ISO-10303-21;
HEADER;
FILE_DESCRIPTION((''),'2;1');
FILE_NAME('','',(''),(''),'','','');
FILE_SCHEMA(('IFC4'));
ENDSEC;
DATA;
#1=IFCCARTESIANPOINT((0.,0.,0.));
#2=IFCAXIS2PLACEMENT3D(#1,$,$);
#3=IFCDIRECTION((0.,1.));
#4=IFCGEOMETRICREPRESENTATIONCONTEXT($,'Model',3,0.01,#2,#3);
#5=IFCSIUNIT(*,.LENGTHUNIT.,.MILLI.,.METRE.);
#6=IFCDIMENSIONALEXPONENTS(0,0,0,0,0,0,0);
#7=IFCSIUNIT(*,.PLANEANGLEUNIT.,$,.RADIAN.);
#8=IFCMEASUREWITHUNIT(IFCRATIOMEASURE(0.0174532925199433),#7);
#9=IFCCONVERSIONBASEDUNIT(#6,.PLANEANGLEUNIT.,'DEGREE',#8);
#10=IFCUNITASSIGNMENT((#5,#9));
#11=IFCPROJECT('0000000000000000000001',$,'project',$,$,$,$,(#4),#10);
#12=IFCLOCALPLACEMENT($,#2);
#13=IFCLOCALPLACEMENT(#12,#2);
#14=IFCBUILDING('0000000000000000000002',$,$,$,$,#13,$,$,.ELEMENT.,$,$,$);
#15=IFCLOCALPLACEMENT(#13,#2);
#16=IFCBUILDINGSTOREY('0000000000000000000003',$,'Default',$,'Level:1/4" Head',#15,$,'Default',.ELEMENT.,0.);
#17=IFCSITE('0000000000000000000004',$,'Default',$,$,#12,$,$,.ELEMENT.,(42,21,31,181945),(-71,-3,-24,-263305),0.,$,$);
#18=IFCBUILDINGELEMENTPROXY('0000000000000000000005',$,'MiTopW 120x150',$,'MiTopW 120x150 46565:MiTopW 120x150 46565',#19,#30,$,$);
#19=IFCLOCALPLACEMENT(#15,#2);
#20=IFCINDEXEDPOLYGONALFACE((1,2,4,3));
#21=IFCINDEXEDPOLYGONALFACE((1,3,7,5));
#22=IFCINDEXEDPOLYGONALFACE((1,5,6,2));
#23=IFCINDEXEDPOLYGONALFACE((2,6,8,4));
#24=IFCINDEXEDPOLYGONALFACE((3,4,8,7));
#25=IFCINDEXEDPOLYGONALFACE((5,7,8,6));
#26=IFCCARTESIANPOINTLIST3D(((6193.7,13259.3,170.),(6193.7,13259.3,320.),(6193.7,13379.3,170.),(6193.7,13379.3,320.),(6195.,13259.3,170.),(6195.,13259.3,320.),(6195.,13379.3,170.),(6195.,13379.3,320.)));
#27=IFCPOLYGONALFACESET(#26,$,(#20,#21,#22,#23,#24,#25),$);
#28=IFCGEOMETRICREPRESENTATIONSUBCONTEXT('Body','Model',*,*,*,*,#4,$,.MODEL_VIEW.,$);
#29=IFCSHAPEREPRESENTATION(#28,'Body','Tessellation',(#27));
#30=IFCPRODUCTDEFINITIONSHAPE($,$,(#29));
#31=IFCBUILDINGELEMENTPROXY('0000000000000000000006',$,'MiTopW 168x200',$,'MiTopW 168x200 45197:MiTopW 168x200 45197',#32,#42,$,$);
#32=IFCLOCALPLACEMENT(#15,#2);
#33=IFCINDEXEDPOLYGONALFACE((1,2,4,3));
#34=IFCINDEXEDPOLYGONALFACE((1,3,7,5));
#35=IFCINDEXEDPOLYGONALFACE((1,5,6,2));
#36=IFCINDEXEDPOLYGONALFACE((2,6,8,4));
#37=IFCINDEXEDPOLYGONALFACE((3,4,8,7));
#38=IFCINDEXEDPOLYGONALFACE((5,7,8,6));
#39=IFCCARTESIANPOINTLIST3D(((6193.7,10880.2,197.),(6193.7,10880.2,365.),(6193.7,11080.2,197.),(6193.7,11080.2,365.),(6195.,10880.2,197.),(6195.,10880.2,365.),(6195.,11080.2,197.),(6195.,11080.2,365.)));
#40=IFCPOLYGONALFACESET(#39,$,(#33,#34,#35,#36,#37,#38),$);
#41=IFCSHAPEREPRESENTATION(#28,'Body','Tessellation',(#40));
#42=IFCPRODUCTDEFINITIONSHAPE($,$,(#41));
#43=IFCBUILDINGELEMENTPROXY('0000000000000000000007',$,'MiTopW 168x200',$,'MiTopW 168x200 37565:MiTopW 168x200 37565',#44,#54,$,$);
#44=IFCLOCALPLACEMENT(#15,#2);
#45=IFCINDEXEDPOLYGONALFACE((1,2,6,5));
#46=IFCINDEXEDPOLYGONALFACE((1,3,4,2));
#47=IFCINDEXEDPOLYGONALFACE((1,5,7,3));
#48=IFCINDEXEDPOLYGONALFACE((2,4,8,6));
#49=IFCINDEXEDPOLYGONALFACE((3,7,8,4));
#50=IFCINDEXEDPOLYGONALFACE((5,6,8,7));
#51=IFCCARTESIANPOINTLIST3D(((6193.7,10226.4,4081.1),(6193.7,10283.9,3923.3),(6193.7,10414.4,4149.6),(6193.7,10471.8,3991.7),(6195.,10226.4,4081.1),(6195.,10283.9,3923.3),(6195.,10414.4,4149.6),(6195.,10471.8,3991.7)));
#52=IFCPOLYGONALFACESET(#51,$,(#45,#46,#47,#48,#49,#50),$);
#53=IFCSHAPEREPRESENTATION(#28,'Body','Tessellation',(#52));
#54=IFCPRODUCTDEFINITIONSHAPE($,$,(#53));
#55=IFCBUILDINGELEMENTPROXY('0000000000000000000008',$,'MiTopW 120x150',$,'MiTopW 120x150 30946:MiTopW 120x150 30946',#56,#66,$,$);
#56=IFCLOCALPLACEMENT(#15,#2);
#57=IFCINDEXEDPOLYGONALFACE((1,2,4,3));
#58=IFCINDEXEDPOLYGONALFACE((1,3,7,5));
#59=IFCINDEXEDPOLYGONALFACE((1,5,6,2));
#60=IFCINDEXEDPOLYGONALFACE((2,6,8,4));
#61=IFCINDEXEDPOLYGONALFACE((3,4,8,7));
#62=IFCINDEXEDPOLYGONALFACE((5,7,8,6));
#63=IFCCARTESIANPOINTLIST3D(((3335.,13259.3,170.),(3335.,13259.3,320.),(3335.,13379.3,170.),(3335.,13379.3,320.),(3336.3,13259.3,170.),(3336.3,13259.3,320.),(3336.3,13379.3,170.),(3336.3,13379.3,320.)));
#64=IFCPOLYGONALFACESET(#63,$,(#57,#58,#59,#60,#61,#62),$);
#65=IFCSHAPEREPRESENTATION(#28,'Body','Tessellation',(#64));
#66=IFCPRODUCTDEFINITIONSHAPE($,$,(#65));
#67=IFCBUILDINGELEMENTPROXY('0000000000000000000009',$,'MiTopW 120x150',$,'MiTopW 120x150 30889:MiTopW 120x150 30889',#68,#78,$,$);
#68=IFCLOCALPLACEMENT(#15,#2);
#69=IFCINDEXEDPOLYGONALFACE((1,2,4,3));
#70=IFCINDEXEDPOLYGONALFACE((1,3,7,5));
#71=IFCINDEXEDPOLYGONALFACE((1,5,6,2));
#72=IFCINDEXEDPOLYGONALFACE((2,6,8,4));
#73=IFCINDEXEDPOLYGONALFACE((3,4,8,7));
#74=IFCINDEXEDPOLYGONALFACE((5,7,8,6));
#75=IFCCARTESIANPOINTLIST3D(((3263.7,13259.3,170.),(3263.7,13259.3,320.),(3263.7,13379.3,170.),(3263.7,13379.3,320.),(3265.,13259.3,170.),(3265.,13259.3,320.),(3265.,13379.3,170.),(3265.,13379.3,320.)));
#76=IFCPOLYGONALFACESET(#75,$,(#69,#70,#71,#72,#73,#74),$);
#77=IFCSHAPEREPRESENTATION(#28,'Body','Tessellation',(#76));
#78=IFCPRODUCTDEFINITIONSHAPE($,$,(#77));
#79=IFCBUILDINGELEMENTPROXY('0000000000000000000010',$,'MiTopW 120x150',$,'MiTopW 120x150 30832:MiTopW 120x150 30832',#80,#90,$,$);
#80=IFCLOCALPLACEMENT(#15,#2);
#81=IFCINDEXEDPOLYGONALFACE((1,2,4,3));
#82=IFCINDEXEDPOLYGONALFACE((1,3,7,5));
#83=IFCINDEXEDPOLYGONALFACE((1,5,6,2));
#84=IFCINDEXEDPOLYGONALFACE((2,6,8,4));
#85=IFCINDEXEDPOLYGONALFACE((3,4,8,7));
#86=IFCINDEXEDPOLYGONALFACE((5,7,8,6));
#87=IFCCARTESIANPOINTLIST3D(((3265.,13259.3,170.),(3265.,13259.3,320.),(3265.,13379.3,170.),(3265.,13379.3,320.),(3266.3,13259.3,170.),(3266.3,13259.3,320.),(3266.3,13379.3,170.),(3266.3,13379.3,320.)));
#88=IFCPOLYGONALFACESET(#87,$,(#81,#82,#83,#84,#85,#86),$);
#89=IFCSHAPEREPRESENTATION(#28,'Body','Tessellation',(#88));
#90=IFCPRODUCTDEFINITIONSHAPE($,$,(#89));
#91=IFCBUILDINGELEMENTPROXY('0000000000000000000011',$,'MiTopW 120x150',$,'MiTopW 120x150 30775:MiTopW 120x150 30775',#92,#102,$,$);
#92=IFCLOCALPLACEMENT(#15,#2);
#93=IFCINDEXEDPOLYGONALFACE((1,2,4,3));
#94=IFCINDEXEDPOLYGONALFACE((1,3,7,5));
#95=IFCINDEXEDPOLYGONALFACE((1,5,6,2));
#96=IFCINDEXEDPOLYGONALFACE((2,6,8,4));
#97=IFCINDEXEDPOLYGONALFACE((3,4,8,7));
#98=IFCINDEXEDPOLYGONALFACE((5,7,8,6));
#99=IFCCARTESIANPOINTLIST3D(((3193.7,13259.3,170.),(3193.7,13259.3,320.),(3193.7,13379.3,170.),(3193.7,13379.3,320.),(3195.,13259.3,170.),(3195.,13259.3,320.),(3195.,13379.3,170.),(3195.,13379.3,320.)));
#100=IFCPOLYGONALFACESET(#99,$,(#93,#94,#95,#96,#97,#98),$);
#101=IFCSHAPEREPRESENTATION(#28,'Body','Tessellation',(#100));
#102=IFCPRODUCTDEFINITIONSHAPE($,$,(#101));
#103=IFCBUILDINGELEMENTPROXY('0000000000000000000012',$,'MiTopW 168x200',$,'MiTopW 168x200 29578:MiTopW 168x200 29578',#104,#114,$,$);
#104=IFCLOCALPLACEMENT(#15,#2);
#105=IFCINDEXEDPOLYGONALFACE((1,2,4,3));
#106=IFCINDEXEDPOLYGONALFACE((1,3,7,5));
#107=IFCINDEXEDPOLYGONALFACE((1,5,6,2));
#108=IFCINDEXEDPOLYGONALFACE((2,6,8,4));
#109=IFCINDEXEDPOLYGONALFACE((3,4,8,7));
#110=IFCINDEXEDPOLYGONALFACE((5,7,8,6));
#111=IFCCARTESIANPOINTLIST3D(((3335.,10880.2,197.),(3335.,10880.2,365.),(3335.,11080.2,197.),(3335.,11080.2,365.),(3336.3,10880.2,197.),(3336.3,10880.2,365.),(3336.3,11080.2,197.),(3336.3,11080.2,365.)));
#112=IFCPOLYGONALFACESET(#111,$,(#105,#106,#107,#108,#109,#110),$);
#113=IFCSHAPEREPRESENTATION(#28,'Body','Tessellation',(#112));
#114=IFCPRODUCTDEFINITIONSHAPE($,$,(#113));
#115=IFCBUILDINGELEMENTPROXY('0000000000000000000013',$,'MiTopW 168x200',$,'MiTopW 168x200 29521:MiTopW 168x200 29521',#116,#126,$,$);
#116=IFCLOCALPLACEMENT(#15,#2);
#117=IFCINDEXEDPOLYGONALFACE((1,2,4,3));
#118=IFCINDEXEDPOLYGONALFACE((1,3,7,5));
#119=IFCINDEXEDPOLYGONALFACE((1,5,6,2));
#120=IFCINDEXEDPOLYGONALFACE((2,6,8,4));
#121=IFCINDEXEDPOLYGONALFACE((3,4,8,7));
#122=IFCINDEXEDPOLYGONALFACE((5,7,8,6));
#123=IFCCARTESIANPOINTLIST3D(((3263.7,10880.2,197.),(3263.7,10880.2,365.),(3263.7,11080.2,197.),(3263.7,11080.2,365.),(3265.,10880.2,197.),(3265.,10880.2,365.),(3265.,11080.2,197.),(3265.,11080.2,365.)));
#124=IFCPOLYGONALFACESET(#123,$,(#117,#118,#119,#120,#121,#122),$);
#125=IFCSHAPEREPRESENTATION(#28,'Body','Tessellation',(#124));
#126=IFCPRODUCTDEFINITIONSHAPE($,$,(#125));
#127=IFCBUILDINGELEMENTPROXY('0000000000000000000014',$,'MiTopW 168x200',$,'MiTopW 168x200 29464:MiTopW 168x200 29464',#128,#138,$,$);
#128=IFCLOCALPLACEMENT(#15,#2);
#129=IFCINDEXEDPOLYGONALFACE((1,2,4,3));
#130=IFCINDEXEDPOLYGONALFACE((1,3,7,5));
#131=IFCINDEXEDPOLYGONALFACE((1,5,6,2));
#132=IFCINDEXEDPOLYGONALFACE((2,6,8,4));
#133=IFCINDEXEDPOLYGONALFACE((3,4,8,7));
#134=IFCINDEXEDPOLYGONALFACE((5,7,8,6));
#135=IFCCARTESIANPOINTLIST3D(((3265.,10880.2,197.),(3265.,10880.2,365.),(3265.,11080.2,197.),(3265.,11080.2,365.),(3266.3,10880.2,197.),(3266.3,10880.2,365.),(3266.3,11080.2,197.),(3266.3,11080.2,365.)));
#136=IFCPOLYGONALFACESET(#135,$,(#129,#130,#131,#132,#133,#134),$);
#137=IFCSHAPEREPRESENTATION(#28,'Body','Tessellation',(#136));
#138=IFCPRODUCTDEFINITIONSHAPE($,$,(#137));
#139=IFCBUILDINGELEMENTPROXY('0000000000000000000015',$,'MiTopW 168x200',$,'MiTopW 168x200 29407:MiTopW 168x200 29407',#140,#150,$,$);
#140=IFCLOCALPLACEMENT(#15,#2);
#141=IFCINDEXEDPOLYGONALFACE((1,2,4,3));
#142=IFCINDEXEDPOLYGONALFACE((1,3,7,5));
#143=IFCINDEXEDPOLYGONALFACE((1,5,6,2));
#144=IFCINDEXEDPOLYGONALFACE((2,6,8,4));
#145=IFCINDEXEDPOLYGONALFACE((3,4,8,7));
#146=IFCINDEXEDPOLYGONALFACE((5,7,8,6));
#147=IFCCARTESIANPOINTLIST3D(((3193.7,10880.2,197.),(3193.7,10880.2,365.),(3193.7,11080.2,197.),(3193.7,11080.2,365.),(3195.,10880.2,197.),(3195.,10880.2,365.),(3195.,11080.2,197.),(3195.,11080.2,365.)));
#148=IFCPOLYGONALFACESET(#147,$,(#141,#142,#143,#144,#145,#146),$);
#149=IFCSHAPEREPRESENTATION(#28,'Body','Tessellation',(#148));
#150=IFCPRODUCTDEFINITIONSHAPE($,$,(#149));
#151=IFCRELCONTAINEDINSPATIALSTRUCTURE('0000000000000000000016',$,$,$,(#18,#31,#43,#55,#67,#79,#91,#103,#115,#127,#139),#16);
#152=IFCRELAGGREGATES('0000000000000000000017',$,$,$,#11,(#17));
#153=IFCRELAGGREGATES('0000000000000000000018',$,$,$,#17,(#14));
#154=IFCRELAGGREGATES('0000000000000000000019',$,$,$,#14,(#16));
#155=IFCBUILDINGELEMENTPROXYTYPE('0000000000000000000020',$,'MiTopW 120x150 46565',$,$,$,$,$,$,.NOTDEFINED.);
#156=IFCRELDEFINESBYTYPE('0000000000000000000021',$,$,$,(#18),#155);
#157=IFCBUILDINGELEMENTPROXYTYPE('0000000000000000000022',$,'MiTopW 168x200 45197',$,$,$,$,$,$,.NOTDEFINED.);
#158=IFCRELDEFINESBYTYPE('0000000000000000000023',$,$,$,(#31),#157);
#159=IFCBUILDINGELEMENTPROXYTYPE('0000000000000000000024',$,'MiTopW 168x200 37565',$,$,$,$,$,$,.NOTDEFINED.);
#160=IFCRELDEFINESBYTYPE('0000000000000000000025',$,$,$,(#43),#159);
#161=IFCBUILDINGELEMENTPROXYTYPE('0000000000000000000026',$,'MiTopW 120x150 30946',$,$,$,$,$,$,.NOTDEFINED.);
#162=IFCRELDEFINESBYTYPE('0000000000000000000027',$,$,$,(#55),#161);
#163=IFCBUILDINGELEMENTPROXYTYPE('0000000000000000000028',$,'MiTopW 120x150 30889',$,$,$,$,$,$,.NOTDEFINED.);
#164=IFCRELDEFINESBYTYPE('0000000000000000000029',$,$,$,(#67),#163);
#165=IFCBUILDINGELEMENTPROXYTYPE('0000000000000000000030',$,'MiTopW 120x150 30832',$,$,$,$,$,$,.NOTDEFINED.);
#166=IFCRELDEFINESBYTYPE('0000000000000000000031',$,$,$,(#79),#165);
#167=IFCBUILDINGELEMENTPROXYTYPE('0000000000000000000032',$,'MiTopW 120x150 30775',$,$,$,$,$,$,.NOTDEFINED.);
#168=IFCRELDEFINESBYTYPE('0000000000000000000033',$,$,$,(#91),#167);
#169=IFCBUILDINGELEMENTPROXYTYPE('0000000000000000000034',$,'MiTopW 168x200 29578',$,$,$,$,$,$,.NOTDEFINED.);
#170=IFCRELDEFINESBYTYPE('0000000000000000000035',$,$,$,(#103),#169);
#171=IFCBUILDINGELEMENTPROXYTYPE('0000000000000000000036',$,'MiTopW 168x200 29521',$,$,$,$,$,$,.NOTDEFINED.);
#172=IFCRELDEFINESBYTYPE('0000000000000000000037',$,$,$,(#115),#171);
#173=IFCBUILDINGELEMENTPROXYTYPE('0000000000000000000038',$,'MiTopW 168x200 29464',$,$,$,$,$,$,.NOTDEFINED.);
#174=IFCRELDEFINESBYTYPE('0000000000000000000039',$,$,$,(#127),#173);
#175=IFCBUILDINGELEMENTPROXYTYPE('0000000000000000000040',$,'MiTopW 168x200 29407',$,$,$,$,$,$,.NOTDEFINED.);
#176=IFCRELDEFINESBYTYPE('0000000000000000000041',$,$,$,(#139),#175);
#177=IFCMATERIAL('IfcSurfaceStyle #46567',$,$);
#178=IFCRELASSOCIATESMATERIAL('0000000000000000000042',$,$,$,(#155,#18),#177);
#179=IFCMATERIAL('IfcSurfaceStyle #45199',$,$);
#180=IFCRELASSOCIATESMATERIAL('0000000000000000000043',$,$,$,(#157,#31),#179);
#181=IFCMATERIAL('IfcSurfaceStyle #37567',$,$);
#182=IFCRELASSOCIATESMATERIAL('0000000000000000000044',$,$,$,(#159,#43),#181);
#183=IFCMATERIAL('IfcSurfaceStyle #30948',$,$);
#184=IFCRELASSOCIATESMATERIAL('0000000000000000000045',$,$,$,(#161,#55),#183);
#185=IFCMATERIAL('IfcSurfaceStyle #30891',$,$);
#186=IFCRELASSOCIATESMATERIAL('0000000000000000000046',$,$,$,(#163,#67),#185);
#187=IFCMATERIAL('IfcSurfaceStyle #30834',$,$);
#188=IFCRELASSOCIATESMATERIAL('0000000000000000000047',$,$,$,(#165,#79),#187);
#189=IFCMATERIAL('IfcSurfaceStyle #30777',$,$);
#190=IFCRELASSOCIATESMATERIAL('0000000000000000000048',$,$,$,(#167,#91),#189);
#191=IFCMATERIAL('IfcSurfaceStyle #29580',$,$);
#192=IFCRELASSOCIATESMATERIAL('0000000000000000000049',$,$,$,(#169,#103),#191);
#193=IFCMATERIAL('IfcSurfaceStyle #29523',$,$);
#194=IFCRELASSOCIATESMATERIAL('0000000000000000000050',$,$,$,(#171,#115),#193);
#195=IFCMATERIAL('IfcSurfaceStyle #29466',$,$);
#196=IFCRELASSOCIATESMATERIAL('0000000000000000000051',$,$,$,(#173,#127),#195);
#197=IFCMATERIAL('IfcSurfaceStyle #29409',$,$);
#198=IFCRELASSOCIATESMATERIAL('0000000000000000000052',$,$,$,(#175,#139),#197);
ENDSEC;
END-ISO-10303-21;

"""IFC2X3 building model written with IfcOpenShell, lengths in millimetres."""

from ifc_helpers import new_model, entity, si_unit, converted_unit, direction, frame, origin, origin_2d_with_axis, place, context, subcontext, project, spatial, polyline, rectangle, outline, extrude, source, transform, mapped, material, type_object, type_shapes, element, save


model = new_model("IFC2X3")

# Units and contexts
model_context = context("Model", 3, precision=0.01, world=origin(), true_north=direction((0.0, 1.0)))
body_context = subcontext(model_context, "Body", "Model", "MODEL_VIEW")
ifc_project = project(units=[si_unit("LENGTHUNIT", "METRE", prefix="MILLI"), converted_unit("PLANEANGLEUNIT", "DEGREE", entity("IfcRatioMeasure", 0.0174532925199433), si_unit("PLANEANGLEUNIT", "RADIAN"), dimensions=[0, 0, 0, 0, 0, 0, 0])], contexts=[model_context])

# Site, building, storey
site_placement = place(None, origin())
site = spatial("IfcSite", under=ifc_project, at=site_placement, Name="Default", CompositionType="ELEMENT", RefLatitude=(42, 21, 31, 181945), RefLongitude=(-71, -3, -24, -263305), RefElevation=0.0)
building_placement = place(site_placement, origin())
building = spatial("IfcBuilding", under=site, at=building_placement, CompositionType="ELEMENT")
storey_placement = place(building_placement, origin())
storey = spatial("IfcBuildingStorey", under=building, at=storey_placement, Name="Default", ObjectType="Level:1/4\" Head", LongName="Default", CompositionType="ELEMENT", Elevation=0.0)

# Building element proxies
ifc_material_1 = material(Name="IfcSurfaceStyle #46567")
building_element_proxy_type_1 = type_object("IfcBuildingElementProxyType", Name="MiTopW 120x150 46565", PredefinedType="NOTDEFINED", material=ifc_material_1)
shared_shape_1 = source(origin(), body_context, "Body", "SweptSolid", [
    extrude(rectangle(XDim=150.0, YDim=120.0, at=origin_2d_with_axis()), frame((75.0, 60.0, 0.0), z_axis=(0.0, 0.0, 1.0), x_axis=(-1.0, 0.0, 0.0)), (0.0, 0.0, 1.0), 1.3),
])
type_shapes(building_element_proxy_type_1, [shared_shape_1])
proxy_1_placement = place(building_placement, frame((6195.0, 13259.3, 170.0), z_axis=(-1.0, 0.0, 0.0), x_axis=(0.0, 0.0, 1.0)))
element("IfcBuildingElementProxy", 1, at=proxy_1_placement, inside=storey, type_object=building_element_proxy_type_1, material=ifc_material_1, Name="MiTopW 120x150", ObjectType="MiTopW 120x150 46565:MiTopW 120x150 46565", context=body_context, shape_type="MappedRepresentation", body=[
    mapped(shared_shape_1, transform((0.0, 0.0, 0.0), scale=1.0)),
])
ifc_material_2 = material(Name="IfcSurfaceStyle #45199")
building_element_proxy_type_2 = type_object("IfcBuildingElementProxyType", Name="MiTopW 168x200 45197", PredefinedType="NOTDEFINED", material=ifc_material_2)
shared_shape_2 = source(origin(), body_context, "Body", "SweptSolid", [
    extrude(rectangle(XDim=200.0, YDim=168.0, at=origin_2d_with_axis()), frame((100.0, 84.0, 0.0), z_axis=(0.0, 0.0, 1.0), x_axis=(-1.0, 0.0, 0.0)), (0.0, 0.0, 1.0), 1.3),
])
type_shapes(building_element_proxy_type_2, [shared_shape_2])
proxy_2_placement = place(building_placement, frame((6195.0, 10880.2, 365.0), z_axis=(-1.0, 0.0, 0.0), x_axis=(0.0, 1.0, 0.0)))
element("IfcBuildingElementProxy", 2, at=proxy_2_placement, inside=storey, type_object=building_element_proxy_type_2, material=ifc_material_2, Name="MiTopW 168x200", ObjectType="MiTopW 168x200 45197:MiTopW 168x200 45197", context=body_context, shape_type="MappedRepresentation", body=[
    mapped(shared_shape_2, transform((0.0, 0.0, 0.0), scale=1.0)),
])
ifc_material_3 = material(Name="IfcSurfaceStyle #37567")
building_element_proxy_type_3 = type_object("IfcBuildingElementProxyType", Name="MiTopW 168x200 37565", PredefinedType="NOTDEFINED", material=ifc_material_3)
shared_shape_3 = source(origin(), body_context, "Body", "SweptSolid", [
    extrude(outline(polyline([(-100.0, -84.0), (100.0, -84.0), (100.0, 84.0), (-100.0, 84.0), (-100.0, -84.0)])), frame((100.0, 84.0, 0.0), z_axis=(0.0, 0.0, 1.0), x_axis=(-1.0, 0.0, 0.0)), (0.0, 0.0, 1.0), 1.3),
])
type_shapes(building_element_proxy_type_3, [shared_shape_3])
proxy_3_placement = place(building_placement, frame((6195.0, 10226.4, 4081.1), z_axis=(-1.0, 0.0, 0.0), x_axis=(0.0, 0.939693, 0.34202)))
element("IfcBuildingElementProxy", 3, at=proxy_3_placement, inside=storey, type_object=building_element_proxy_type_3, material=ifc_material_3, Name="MiTopW 168x200", ObjectType="MiTopW 168x200 37565:MiTopW 168x200 37565", context=body_context, shape_type="MappedRepresentation", body=[
    mapped(shared_shape_3, transform((0.0, 0.0, 0.0), scale=1.0)),
])
ifc_material_4 = material(Name="IfcSurfaceStyle #30948")
building_element_proxy_type_4 = type_object("IfcBuildingElementProxyType", Name="MiTopW 120x150 30946", PredefinedType="NOTDEFINED", material=ifc_material_4)
shared_shape_4 = source(origin(), body_context, "Body", "SweptSolid", [
    extrude(rectangle(XDim=150.0, YDim=120.0, at=origin_2d_with_axis()), frame((75.0, 60.0, 0.0), z_axis=(0.0, 0.0, 1.0), x_axis=(-1.0, 0.0, 0.0)), (0.0, 0.0, 1.0), 1.3),
])
type_shapes(building_element_proxy_type_4, [shared_shape_4])
proxy_4_placement = place(building_placement, frame((3336.3, 13259.3, 170.0), z_axis=(-1.0, 0.0, 0.0), x_axis=(0.0, 0.0, 1.0)))
element("IfcBuildingElementProxy", 4, at=proxy_4_placement, inside=storey, type_object=building_element_proxy_type_4, material=ifc_material_4, Name="MiTopW 120x150", ObjectType="MiTopW 120x150 30946:MiTopW 120x150 30946", context=body_context, shape_type="MappedRepresentation", body=[
    mapped(shared_shape_4, transform((0.0, 0.0, 0.0), scale=1.0)),
])
ifc_material_5 = material(Name="IfcSurfaceStyle #30891")
building_element_proxy_type_5 = type_object("IfcBuildingElementProxyType", Name="MiTopW 120x150 30889", PredefinedType="NOTDEFINED", material=ifc_material_5)
shared_shape_5 = source(origin(), body_context, "Body", "SweptSolid", [
    extrude(rectangle(XDim=150.0, YDim=120.0, at=origin_2d_with_axis()), frame((75.0, 60.0, 0.0), z_axis=(0.0, 0.0, 1.0), x_axis=(-1.0, 0.0, 0.0)), (0.0, 0.0, 1.0), 1.3),
])
type_shapes(building_element_proxy_type_5, [shared_shape_5])
proxy_5_placement = place(building_placement, frame((3265.0, 13259.3, 170.0), z_axis=(-1.0, 0.0, 0.0), x_axis=(0.0, 0.0, 1.0)))
element("IfcBuildingElementProxy", 5, at=proxy_5_placement, inside=storey, type_object=building_element_proxy_type_5, material=ifc_material_5, Name="MiTopW 120x150", ObjectType="MiTopW 120x150 30889:MiTopW 120x150 30889", context=body_context, shape_type="MappedRepresentation", body=[
    mapped(shared_shape_5, transform((0.0, 0.0, 0.0), scale=1.0)),
])
ifc_material_6 = material(Name="IfcSurfaceStyle #30834")
building_element_proxy_type_6 = type_object("IfcBuildingElementProxyType", Name="MiTopW 120x150 30832", PredefinedType="NOTDEFINED", material=ifc_material_6)
shared_shape_6 = source(origin(), body_context, "Body", "SweptSolid", [
    extrude(rectangle(XDim=150.0, YDim=120.0, at=origin_2d_with_axis()), frame((75.0, 60.0, 0.0), z_axis=(0.0, 0.0, 1.0), x_axis=(-1.0, 0.0, 0.0)), (0.0, 0.0, 1.0), 1.3),
])
type_shapes(building_element_proxy_type_6, [shared_shape_6])
proxy_6_placement = place(building_placement, frame((3266.3, 13259.3, 170.0), z_axis=(-1.0, 0.0, 0.0), x_axis=(0.0, 0.0, 1.0)))
element("IfcBuildingElementProxy", 6, at=proxy_6_placement, inside=storey, type_object=building_element_proxy_type_6, material=ifc_material_6, Name="MiTopW 120x150", ObjectType="MiTopW 120x150 30832:MiTopW 120x150 30832", context=body_context, shape_type="MappedRepresentation", body=[
    mapped(shared_shape_6, transform((0.0, 0.0, 0.0), scale=1.0)),
])
ifc_material_7 = material(Name="IfcSurfaceStyle #30777")
building_element_proxy_type_7 = type_object("IfcBuildingElementProxyType", Name="MiTopW 120x150 30775", PredefinedType="NOTDEFINED", material=ifc_material_7)
shared_shape_7 = source(origin(), body_context, "Body", "SweptSolid", [
    extrude(rectangle(XDim=150.0, YDim=120.0, at=origin_2d_with_axis()), frame((75.0, 60.0, 0.0), z_axis=(0.0, 0.0, 1.0), x_axis=(-1.0, 0.0, 0.0)), (0.0, 0.0, 1.0), 1.3),
])
type_shapes(building_element_proxy_type_7, [shared_shape_7])
proxy_7_placement = place(building_placement, frame((3195.0, 13259.3, 170.0), z_axis=(-1.0, 0.0, 0.0), x_axis=(0.0, 0.0, 1.0)))
element("IfcBuildingElementProxy", 7, at=proxy_7_placement, inside=storey, type_object=building_element_proxy_type_7, material=ifc_material_7, Name="MiTopW 120x150", ObjectType="MiTopW 120x150 30775:MiTopW 120x150 30775", context=body_context, shape_type="MappedRepresentation", body=[
    mapped(shared_shape_7, transform((0.0, 0.0, 0.0), scale=1.0)),
])
ifc_material_8 = material(Name="IfcSurfaceStyle #29580")
building_element_proxy_type_8 = type_object("IfcBuildingElementProxyType", Name="MiTopW 168x200 29578", PredefinedType="NOTDEFINED", material=ifc_material_8)
shared_shape_8 = source(origin(), body_context, "Body", "SweptSolid", [
    extrude(rectangle(XDim=200.0, YDim=168.0, at=origin_2d_with_axis()), frame((100.0, 84.0, 0.0), z_axis=(0.0, 0.0, 1.0), x_axis=(-1.0, 0.0, 0.0)), (0.0, 0.0, 1.0), 1.3),
])
type_shapes(building_element_proxy_type_8, [shared_shape_8])
proxy_8_placement = place(building_placement, frame((3336.3, 10880.2, 365.0), z_axis=(-1.0, 0.0, 0.0), x_axis=(0.0, 1.0, 0.0)))
element("IfcBuildingElementProxy", 8, at=proxy_8_placement, inside=storey, type_object=building_element_proxy_type_8, material=ifc_material_8, Name="MiTopW 168x200", ObjectType="MiTopW 168x200 29578:MiTopW 168x200 29578", context=body_context, shape_type="MappedRepresentation", body=[
    mapped(shared_shape_8, transform((0.0, 0.0, 0.0), scale=1.0)),
])
ifc_material_9 = material(Name="IfcSurfaceStyle #29523")
building_element_proxy_type_9 = type_object("IfcBuildingElementProxyType", Name="MiTopW 168x200 29521", PredefinedType="NOTDEFINED", material=ifc_material_9)
shared_shape_9 = source(origin(), body_context, "Body", "SweptSolid", [
    extrude(rectangle(XDim=200.0, YDim=168.0, at=origin_2d_with_axis()), frame((100.0, 84.0, 0.0), z_axis=(0.0, 0.0, 1.0), x_axis=(-1.0, 0.0, 0.0)), (0.0, 0.0, 1.0), 1.3),
])
type_shapes(building_element_proxy_type_9, [shared_shape_9])
proxy_9_placement = place(building_placement, frame((3265.0, 10880.2, 365.0), z_axis=(-1.0, 0.0, 0.0), x_axis=(0.0, 1.0, 0.0)))
element("IfcBuildingElementProxy", 9, at=proxy_9_placement, inside=storey, type_object=building_element_proxy_type_9, material=ifc_material_9, Name="MiTopW 168x200", ObjectType="MiTopW 168x200 29521:MiTopW 168x200 29521", context=body_context, shape_type="MappedRepresentation", body=[
    mapped(shared_shape_9, transform((0.0, 0.0, 0.0), scale=1.0)),
])
ifc_material_10 = material(Name="IfcSurfaceStyle #29466")
building_element_proxy_type_10 = type_object("IfcBuildingElementProxyType", Name="MiTopW 168x200 29464", PredefinedType="NOTDEFINED", material=ifc_material_10)
shared_shape_10 = source(origin(), body_context, "Body", "SweptSolid", [
    extrude(rectangle(XDim=200.0, YDim=168.0, at=origin_2d_with_axis()), frame((100.0, 84.0, 0.0), z_axis=(0.0, 0.0, 1.0), x_axis=(-1.0, 0.0, 0.0)), (0.0, 0.0, 1.0), 1.3),
])
type_shapes(building_element_proxy_type_10, [shared_shape_10])
proxy_10_placement = place(building_placement, frame((3266.3, 10880.2, 365.0), z_axis=(-1.0, 0.0, 0.0), x_axis=(0.0, 1.0, 0.0)))
element("IfcBuildingElementProxy", 10, at=proxy_10_placement, inside=storey, type_object=building_element_proxy_type_10, material=ifc_material_10, Name="MiTopW 168x200", ObjectType="MiTopW 168x200 29464:MiTopW 168x200 29464", context=body_context, shape_type="MappedRepresentation", body=[
    mapped(shared_shape_10, transform((0.0, 0.0, 0.0), scale=1.0)),
])
ifc_material_11 = material(Name="IfcSurfaceStyle #29409")
building_element_proxy_type_11 = type_object("IfcBuildingElementProxyType", Name="MiTopW 168x200 29407", PredefinedType="NOTDEFINED", material=ifc_material_11)
shared_shape_11 = source(origin(), body_context, "Body", "SweptSolid", [
    extrude(rectangle(XDim=200.0, YDim=168.0, at=origin_2d_with_axis()), frame((100.0, 84.0, 0.0), z_axis=(0.0, 0.0, 1.0), x_axis=(-1.0, 0.0, 0.0)), (0.0, 0.0, 1.0), 1.3),
])
type_shapes(building_element_proxy_type_11, [shared_shape_11])
proxy_11_placement = place(building_placement, frame((3195.0, 10880.2, 365.0), z_axis=(-1.0, 0.0, 0.0), x_axis=(0.0, 1.0, 0.0)))
element("IfcBuildingElementProxy", 11, at=proxy_11_placement, inside=storey, type_object=building_element_proxy_type_11, material=ifc_material_11, Name="MiTopW 168x200", ObjectType="MiTopW 168x200 29407:MiTopW 168x200 29407", context=body_context, shape_type="MappedRepresentation", body=[
    mapped(shared_shape_11, transform((0.0, 0.0, 0.0), scale=1.0)),
])

save(model, "model.ifc")
